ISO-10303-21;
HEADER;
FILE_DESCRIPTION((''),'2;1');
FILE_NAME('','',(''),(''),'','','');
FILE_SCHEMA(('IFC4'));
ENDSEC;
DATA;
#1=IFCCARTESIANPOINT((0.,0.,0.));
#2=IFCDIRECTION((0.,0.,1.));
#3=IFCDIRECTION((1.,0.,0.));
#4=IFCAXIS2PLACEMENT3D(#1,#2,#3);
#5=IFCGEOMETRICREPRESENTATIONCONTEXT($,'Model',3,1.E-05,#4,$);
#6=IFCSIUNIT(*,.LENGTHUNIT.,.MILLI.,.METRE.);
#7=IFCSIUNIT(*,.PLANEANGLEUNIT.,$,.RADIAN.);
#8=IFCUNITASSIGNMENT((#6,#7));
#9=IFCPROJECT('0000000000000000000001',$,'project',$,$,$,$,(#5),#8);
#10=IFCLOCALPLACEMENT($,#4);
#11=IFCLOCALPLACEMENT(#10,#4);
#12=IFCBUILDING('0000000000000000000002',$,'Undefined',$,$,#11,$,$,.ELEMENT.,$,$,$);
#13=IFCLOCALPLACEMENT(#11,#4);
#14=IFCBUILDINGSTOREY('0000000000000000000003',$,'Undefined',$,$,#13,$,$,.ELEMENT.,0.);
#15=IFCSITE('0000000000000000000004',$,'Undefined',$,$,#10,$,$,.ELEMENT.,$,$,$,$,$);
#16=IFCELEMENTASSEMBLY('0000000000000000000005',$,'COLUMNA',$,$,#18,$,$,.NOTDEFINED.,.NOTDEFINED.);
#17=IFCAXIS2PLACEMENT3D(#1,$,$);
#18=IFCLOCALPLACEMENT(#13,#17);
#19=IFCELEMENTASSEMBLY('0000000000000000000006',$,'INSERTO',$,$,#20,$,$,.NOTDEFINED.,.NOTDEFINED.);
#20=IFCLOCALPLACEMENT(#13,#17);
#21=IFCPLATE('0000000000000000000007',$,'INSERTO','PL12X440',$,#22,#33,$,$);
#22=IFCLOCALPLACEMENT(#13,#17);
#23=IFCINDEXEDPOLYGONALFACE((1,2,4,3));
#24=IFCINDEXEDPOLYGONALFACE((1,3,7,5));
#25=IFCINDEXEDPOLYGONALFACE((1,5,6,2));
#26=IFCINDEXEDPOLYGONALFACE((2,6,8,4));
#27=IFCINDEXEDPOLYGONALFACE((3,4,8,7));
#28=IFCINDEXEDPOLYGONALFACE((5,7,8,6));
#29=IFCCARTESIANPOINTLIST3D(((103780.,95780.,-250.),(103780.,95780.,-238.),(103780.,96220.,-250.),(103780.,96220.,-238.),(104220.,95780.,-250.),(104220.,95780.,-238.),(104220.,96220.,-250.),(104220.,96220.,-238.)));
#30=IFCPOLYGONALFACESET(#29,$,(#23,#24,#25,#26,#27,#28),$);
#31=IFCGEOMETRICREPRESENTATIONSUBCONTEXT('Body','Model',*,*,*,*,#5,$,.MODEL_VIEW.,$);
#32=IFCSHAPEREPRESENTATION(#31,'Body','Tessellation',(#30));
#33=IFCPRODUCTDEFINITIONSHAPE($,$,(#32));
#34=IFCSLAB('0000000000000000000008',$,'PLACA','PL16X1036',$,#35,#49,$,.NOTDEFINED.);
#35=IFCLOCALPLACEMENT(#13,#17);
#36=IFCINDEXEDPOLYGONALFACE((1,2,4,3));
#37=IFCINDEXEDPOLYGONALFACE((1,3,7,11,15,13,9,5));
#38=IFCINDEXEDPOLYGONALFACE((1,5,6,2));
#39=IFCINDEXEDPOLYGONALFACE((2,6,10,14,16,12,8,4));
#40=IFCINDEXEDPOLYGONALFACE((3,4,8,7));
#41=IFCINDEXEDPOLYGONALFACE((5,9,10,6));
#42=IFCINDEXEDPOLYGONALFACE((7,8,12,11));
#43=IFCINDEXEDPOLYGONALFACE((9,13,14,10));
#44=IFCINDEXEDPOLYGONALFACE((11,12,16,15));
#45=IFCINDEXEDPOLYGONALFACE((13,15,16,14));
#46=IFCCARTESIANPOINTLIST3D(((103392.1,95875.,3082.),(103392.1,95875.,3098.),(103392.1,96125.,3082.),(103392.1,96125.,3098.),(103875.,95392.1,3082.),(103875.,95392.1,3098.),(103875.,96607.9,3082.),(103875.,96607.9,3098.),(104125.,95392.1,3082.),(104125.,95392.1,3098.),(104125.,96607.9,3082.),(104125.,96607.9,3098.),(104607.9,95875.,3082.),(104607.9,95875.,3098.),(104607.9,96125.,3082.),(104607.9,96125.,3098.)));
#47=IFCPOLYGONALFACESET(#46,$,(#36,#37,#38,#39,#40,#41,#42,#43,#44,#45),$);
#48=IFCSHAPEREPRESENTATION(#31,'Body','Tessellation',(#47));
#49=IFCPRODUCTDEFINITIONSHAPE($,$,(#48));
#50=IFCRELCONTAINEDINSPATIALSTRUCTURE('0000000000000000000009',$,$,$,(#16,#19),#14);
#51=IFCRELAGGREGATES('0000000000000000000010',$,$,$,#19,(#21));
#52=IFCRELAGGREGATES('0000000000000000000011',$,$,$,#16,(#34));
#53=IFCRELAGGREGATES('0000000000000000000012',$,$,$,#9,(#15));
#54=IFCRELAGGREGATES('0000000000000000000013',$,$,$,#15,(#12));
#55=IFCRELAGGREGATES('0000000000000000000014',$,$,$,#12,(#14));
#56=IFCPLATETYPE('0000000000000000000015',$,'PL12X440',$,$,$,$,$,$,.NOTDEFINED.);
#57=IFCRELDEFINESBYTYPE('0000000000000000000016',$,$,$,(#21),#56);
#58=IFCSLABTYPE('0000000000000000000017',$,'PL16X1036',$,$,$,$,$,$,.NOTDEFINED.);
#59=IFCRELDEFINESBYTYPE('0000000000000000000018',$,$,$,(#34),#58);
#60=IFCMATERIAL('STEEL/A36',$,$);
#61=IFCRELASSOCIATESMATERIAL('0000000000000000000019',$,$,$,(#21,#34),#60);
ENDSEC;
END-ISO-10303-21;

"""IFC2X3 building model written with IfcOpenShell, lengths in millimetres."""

from ifc_helpers import new_model, si_unit, frame, origin_with_axes, place, context, subcontext, project, spatial, polyline, outline, extrude, material, type_object, element, aggregate, save


model = new_model("IFC2X3")

# Units and contexts
model_context = context("Model", 3, precision=1e-05, world=origin_with_axes())
body_context = subcontext(model_context, "Body", "Model", "MODEL_VIEW")
ifc_project = project(units=[si_unit("LENGTHUNIT", "METRE", prefix="MILLI"), si_unit("PLANEANGLEUNIT", "RADIAN")], contexts=[model_context])

# Site, building, storey
site_placement = place(None, origin_with_axes())
site = spatial("IfcSite", under=ifc_project, at=site_placement, Name="Undefined", CompositionType="ELEMENT")
building_placement = place(site_placement, origin_with_axes())
building = spatial("IfcBuilding", under=site, at=building_placement, Name="Undefined", CompositionType="ELEMENT")
storey_placement = place(building_placement, origin_with_axes())
storey = spatial("IfcBuildingStorey", under=building, at=storey_placement, Name="Undefined", CompositionType="ELEMENT", Elevation=0.0)

# Shared definitions
ifc_material_1 = material(Name="STEEL/A36")

# Element assembly
assembly_1_placement = place(storey_placement, origin_with_axes())
assembly_1 = element("IfcElementAssembly", 1, at=assembly_1_placement, inside=storey, Name="COLUMNA", AssemblyPlace="NOTDEFINED", PredefinedType="NOTDEFINED")

# Element assembly, plate
assembly_2_placement = place(storey_placement, origin_with_axes())
assembly_2 = element("IfcElementAssembly", 2, at=assembly_2_placement, inside=storey, Name="INSERTO", AssemblyPlace="NOTDEFINED", PredefinedType="NOTDEFINED")
plate_type_1 = type_object("IfcPlateType", Name="PL12X440", PredefinedType="NOTDEFINED")
plate_1_placement = place(assembly_2_placement, frame((104220.0, 96000.0, -244.0), z_axis=(0.0, 0.0, 1.0), x_axis=(-1.0, 0.0, 0.0)))
plate_1 = element("IfcPlate", 3, at=plate_1_placement, type_object=plate_type_1, material=ifc_material_1, Name="INSERTO", Description="PL12X440", context=body_context, shape_type="SweptSolid", body=[
    extrude(outline(polyline([(0.0, -220.0), (0.0, 220.0), (440.0, 220.0), (440.0, -220.0), (0.0, -220.0)])), frame((0.0, 0.0, -6.0), z_axis=(0.0, 0.0, 1.0), x_axis=(1.0, 0.0, 0.0)), (0.0, 0.0, 1.0), 12.0),
])
aggregate(assembly_2, [plate_1])

# Slab
slab_type = type_object("IfcSlabType", Name="PL16X1036", PredefinedType="NOTDEFINED")
slab_placement = place(assembly_1_placement, frame((104125.0, 95392.1, 3090.0), z_axis=(0.0, 0.0, 1.0), x_axis=(0.707107, 0.707107, 0.0)))
slab = element("IfcSlab", 4, at=slab_placement, type_object=slab_type, material=ifc_material_1, Name="PLACA", Description="PL16X1036", PredefinedType="NOTDEFINED", context=body_context, shape_type="SweptSolid", body=[
    extrude(outline(polyline([(0.0, 0.0), (682.9, 0.0), (859.7, 176.8), (859.7, 859.7), (682.9, 1036.5), (0.0, 1036.5), (-176.8, 859.7), (-176.8, 176.8), (0.0, 0.0)])), frame((0.0, 0.0, -8.0), z_axis=(0.0, 0.0, 1.0), x_axis=(1.0, 0.0, 0.0)), (0.0, 0.0, 1.0), 16.0),
])

aggregate(assembly_1, [slab])

save(model, "model.ifc")
